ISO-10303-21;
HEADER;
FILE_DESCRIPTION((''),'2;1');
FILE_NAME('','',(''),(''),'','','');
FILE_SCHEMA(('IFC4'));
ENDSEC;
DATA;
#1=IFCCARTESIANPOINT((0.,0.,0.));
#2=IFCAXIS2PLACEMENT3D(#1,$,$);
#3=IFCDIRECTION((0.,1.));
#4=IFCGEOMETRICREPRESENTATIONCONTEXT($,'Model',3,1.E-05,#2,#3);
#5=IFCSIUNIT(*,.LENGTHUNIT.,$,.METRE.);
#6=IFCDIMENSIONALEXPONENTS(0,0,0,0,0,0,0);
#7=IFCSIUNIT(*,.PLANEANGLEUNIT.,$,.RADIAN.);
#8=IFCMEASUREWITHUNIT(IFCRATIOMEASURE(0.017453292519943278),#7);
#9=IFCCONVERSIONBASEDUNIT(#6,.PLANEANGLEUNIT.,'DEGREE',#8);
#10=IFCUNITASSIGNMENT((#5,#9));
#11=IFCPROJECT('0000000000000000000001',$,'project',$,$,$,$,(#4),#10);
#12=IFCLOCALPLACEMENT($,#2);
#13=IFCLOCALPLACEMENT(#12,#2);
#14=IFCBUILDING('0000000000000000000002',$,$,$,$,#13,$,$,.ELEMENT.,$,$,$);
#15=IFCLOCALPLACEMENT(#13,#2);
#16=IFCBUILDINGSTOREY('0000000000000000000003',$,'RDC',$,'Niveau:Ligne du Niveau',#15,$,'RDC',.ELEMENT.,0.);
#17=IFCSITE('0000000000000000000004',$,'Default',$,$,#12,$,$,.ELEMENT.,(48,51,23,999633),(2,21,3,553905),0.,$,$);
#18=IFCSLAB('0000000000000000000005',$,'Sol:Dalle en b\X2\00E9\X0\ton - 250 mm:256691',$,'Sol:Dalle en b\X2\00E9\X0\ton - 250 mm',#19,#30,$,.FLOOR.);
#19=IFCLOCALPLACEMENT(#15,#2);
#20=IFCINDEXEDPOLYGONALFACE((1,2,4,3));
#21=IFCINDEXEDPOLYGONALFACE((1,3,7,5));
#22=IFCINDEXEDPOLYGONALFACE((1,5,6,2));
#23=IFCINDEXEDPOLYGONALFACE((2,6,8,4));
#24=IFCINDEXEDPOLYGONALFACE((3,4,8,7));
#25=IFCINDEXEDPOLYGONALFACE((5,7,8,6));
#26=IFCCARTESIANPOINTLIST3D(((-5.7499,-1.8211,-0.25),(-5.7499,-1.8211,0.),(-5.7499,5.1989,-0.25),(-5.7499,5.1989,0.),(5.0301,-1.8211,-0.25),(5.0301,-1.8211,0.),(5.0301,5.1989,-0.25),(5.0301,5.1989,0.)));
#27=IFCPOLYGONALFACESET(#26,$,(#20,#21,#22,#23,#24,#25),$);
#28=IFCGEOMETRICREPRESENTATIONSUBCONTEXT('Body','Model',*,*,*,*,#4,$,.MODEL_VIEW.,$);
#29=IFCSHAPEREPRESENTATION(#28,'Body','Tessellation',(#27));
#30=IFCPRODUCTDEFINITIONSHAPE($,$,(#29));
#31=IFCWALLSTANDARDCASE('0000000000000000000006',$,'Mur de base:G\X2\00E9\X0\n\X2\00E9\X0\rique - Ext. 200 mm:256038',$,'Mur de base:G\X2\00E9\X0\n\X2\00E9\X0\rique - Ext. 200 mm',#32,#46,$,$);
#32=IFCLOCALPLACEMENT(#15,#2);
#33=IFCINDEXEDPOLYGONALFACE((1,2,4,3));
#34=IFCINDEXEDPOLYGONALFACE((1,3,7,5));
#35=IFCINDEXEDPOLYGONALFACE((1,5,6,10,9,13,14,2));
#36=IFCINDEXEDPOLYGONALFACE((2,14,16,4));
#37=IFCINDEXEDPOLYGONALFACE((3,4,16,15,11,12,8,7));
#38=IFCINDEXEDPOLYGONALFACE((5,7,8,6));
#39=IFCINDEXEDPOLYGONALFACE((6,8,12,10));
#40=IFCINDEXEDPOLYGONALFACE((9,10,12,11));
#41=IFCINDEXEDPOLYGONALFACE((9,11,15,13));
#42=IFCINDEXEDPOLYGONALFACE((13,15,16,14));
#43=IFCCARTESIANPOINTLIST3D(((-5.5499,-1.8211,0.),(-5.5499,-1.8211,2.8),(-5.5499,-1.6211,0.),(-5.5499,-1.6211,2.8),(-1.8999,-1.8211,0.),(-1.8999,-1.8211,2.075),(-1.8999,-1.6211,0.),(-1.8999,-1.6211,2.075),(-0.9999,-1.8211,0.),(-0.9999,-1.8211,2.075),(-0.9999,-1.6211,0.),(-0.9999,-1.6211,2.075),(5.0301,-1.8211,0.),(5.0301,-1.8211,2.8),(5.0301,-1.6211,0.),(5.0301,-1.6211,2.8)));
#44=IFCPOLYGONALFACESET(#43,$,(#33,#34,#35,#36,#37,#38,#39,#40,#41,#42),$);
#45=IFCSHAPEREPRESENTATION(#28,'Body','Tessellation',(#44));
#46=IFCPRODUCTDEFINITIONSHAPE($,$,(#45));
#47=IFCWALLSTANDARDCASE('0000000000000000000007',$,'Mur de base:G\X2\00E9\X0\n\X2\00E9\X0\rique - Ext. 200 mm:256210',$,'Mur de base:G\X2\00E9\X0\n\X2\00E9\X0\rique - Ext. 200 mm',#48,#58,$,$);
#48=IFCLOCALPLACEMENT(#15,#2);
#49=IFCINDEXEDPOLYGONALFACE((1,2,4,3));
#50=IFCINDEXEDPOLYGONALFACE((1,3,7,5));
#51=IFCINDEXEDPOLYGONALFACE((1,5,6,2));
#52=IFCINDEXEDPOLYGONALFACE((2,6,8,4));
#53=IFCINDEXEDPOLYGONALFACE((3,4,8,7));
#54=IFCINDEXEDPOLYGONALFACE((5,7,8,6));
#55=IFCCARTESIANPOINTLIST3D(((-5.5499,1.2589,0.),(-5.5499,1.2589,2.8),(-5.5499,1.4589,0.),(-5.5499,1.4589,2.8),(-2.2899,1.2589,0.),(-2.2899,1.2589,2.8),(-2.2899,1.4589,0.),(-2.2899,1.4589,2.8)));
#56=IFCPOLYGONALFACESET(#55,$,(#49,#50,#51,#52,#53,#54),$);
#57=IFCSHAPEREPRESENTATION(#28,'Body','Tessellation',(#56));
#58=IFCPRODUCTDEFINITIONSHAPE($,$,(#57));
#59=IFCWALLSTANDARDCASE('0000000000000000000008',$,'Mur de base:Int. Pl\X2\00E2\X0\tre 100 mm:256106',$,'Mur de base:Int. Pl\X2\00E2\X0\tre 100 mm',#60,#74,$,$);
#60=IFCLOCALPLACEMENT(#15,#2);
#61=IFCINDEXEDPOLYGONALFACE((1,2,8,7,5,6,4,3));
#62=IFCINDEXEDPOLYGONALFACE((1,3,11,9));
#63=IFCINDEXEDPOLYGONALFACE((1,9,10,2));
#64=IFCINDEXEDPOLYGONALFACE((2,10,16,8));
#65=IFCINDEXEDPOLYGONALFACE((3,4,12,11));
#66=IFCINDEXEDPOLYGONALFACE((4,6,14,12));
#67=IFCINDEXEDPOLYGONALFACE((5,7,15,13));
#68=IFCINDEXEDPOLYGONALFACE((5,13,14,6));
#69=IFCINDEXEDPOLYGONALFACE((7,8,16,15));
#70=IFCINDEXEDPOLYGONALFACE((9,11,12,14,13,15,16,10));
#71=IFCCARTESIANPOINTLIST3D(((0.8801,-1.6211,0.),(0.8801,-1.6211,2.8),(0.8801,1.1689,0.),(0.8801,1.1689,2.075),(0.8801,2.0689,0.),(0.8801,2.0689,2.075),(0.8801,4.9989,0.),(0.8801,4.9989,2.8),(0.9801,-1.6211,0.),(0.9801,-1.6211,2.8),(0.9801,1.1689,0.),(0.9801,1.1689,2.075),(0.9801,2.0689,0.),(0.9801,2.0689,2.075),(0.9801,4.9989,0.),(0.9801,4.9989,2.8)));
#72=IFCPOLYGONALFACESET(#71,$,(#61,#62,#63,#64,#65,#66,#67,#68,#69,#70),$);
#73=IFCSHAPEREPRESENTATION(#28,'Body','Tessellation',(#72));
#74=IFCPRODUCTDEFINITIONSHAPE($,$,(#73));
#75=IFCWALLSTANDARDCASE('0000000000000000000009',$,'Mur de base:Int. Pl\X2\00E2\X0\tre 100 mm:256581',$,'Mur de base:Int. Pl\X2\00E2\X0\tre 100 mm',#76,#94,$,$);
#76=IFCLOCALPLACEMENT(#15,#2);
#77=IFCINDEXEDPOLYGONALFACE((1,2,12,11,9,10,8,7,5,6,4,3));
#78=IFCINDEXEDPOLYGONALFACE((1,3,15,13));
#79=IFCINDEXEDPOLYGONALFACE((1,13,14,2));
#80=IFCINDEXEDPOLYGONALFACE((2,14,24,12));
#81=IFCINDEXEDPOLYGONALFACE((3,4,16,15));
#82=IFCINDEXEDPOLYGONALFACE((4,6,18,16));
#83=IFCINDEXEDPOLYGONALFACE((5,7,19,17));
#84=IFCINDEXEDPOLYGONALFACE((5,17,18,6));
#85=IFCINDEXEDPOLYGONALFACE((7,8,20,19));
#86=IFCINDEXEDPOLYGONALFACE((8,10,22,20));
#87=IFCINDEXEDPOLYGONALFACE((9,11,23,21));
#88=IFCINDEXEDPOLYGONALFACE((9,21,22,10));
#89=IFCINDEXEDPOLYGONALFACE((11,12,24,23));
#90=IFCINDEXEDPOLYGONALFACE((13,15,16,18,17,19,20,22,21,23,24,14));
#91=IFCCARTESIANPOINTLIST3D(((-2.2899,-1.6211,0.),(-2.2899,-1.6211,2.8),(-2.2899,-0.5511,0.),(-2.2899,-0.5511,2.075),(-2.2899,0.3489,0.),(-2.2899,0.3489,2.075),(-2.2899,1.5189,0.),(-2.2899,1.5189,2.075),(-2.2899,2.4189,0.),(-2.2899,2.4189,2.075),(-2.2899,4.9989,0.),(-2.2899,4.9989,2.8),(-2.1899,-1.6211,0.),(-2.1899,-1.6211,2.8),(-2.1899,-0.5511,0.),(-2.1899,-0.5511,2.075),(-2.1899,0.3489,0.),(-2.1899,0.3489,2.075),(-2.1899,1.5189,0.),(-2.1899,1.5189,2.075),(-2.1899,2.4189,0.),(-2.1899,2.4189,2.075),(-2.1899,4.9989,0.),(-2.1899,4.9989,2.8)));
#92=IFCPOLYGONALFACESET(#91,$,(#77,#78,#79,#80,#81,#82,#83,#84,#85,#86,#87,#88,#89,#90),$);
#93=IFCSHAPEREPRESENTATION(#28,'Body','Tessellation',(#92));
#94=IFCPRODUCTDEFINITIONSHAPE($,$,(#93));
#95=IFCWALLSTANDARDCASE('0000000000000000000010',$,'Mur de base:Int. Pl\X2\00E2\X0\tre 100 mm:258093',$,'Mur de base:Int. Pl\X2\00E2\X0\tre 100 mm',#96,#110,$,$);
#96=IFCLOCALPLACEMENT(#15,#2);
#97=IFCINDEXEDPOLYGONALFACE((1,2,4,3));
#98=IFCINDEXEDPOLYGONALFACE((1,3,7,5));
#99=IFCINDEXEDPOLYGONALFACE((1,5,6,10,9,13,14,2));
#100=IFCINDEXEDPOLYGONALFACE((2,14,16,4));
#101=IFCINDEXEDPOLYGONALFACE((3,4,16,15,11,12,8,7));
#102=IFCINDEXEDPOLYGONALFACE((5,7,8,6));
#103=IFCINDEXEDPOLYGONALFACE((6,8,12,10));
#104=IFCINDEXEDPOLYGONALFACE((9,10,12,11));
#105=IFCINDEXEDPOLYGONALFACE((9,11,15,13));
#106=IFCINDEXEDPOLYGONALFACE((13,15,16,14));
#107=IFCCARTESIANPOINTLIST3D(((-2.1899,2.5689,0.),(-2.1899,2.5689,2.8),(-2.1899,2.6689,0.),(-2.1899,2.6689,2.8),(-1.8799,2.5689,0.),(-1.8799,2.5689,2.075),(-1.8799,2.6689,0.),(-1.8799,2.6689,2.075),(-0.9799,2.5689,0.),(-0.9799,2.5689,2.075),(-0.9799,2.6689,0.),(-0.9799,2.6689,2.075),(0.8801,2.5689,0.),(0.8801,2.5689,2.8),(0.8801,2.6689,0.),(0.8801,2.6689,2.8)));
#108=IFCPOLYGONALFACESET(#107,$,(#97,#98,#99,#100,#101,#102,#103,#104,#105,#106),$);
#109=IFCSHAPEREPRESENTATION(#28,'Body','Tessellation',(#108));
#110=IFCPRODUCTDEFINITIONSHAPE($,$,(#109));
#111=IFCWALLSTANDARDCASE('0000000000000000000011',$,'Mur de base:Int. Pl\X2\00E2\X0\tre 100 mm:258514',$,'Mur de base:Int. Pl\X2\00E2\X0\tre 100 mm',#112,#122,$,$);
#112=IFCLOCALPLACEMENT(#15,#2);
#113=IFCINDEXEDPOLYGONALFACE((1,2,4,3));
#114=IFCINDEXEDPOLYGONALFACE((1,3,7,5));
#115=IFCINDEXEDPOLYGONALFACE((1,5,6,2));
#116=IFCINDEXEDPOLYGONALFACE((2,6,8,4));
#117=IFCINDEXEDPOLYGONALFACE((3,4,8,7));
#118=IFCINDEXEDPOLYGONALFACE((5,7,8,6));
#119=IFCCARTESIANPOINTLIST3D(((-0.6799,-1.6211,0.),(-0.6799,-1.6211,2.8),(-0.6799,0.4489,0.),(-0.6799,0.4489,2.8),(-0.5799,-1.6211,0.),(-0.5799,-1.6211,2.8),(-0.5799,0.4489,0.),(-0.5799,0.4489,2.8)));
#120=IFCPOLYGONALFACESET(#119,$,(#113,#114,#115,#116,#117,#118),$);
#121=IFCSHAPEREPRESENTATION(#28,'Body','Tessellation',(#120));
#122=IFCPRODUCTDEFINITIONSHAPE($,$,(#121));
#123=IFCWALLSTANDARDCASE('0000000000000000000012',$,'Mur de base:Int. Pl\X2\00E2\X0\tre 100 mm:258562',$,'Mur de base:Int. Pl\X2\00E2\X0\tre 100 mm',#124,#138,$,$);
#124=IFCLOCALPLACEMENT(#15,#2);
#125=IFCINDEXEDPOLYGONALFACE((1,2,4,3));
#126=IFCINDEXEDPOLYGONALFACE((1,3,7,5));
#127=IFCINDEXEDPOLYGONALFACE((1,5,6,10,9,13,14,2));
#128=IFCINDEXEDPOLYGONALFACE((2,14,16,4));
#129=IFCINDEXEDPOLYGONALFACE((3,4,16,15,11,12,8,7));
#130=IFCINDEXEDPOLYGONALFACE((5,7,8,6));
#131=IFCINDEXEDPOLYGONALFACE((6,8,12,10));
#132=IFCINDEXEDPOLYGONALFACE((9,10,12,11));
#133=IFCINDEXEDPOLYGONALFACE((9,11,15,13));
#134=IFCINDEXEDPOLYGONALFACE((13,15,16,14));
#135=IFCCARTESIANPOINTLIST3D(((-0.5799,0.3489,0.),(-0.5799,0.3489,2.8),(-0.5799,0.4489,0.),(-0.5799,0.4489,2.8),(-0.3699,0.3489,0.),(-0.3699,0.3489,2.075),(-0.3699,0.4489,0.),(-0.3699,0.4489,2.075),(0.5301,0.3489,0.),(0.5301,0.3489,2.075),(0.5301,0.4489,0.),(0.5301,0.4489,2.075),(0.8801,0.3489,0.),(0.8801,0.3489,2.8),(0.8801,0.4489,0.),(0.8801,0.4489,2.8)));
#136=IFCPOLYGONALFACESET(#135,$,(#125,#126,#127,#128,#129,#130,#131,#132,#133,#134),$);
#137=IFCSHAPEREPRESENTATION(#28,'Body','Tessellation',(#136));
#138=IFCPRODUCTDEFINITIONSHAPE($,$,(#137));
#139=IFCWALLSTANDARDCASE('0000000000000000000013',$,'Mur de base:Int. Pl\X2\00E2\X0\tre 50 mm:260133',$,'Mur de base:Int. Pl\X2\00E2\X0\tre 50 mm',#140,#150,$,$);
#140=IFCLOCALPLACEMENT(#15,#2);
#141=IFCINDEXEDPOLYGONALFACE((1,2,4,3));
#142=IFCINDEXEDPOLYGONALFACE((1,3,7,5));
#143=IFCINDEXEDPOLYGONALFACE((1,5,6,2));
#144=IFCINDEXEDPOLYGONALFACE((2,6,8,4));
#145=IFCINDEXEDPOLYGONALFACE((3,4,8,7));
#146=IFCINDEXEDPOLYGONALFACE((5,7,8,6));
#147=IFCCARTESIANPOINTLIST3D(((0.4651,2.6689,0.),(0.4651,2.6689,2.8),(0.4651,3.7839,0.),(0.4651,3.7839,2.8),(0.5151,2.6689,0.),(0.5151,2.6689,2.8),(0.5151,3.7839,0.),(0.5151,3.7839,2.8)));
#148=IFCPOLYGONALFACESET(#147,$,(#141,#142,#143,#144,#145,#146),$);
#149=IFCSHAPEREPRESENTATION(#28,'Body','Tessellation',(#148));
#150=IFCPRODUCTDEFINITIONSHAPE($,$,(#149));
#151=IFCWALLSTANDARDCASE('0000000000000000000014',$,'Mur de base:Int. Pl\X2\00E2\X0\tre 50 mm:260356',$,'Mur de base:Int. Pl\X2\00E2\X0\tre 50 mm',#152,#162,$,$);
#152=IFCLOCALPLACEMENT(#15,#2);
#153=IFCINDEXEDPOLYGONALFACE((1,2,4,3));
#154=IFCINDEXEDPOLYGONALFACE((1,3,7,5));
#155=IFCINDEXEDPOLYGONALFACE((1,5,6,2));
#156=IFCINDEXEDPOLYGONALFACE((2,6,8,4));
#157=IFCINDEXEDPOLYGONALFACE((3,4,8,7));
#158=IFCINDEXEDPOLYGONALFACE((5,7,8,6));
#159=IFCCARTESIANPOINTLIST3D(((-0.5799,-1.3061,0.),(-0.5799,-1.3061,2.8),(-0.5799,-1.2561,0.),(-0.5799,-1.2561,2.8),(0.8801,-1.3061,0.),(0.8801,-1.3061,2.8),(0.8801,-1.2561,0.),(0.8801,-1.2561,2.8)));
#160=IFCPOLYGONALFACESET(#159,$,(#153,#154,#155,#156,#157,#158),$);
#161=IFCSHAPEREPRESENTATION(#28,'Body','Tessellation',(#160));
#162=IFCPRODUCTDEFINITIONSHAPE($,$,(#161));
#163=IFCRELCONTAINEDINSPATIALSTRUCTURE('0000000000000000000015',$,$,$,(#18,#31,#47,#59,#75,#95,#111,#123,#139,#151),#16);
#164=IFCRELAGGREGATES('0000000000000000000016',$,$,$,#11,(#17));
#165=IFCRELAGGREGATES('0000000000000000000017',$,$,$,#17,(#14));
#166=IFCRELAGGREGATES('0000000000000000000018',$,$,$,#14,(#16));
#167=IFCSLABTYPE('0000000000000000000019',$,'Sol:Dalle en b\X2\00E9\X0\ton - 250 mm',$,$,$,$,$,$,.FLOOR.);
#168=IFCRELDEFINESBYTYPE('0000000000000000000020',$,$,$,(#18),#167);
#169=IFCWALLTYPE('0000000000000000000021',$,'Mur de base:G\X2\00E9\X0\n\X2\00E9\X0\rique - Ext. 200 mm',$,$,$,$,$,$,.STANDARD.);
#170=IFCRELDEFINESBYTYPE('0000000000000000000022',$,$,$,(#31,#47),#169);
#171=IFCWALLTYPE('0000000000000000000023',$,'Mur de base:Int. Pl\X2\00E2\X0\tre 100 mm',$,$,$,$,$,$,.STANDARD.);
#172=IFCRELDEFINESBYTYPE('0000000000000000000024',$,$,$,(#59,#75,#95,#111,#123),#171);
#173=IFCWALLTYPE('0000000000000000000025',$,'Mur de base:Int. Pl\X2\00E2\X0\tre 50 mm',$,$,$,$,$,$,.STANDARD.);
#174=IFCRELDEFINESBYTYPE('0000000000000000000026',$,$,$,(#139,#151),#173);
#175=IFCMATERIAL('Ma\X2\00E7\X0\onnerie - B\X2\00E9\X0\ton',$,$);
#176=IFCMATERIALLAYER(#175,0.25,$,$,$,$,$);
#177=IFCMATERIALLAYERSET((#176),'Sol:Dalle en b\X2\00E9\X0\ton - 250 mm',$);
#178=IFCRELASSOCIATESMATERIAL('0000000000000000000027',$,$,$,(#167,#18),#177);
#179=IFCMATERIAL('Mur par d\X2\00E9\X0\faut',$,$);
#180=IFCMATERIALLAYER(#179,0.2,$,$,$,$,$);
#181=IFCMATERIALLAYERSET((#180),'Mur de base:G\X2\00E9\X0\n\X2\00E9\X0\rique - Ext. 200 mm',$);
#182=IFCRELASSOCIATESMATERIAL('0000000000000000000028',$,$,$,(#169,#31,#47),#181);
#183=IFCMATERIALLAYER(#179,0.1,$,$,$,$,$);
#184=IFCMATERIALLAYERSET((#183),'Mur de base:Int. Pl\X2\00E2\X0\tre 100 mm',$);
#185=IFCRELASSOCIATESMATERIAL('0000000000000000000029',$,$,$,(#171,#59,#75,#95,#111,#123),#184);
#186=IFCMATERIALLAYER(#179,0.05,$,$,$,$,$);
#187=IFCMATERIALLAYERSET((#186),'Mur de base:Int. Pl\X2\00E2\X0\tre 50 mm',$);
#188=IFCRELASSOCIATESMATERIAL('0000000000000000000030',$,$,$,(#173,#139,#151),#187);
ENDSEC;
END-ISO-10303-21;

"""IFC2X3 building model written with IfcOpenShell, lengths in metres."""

from ifc_helpers import new_model, entity, si_unit, converted_unit, direction, frame, frame_2d, origin, origin_2d_with_axis, place, context, subcontext, project, spatial, rectangle, extrude, material, layer, layer_set, layer_usage, type_object, element, save


model = new_model("IFC2X3")

# Units and contexts
model_context = context("Model", 3, precision=1e-05, world=origin(), true_north=direction((0.0, 1.0)))
body_context = subcontext(model_context, "Body", "Model", "MODEL_VIEW")
ifc_project = project(units=[si_unit("LENGTHUNIT", "METRE"), converted_unit("PLANEANGLEUNIT", "DEGREE", entity("IfcRatioMeasure", 0.017453292519943278), si_unit("PLANEANGLEUNIT", "RADIAN"), dimensions=[0, 0, 0, 0, 0, 0, 0])], contexts=[model_context])

# Site, building, storey
site_placement = place(None, origin())
site = spatial("IfcSite", under=ifc_project, at=site_placement, Name="Default", CompositionType="ELEMENT", RefLatitude=(48, 51, 23, 999633), RefLongitude=(2, 21, 3, 553905), RefElevation=0.0)
building_placement = place(site_placement, origin())
building = spatial("IfcBuilding", under=site, at=building_placement, CompositionType="ELEMENT")
storey_placement = place(building_placement, origin())
storey = spatial("IfcBuildingStorey", under=building, at=storey_placement, Name="RDC", ObjectType="Niveau:Ligne du Niveau", LongName="RDC", CompositionType="ELEMENT", Elevation=0.0)

# Slab
ifc_material_1 = material(Name="Maçonnerie - Béton")
ifc_layer_1 = layer(ifc_material_1, 0.25)
ifc_layer_set_1 = layer_set([ifc_layer_1], Name="Sol:Dalle en béton - 250 mm")
ifc_layer_usage_1 = layer_usage(ifc_layer_set_1, "AXIS3", "POSITIVE", 0.0)
slab_type = type_object("IfcSlabType", Name="Sol:Dalle en béton - 250 mm", PredefinedType="FLOOR", material=ifc_layer_set_1)
slab_placement = place(storey_placement, origin())
element("IfcSlab", 1, at=slab_placement, inside=storey, type_object=slab_type, material=ifc_layer_usage_1, Name="Sol:Dalle en béton - 250 mm:256691", ObjectType="Sol:Dalle en béton - 250 mm", PredefinedType="FLOOR", context=body_context, shape_type="SweptSolid", body=[
    extrude(rectangle(XDim=7.02, YDim=10.78, at=origin_2d_with_axis()), frame((-0.3599, 1.6889, 0.0), z_axis=(0.0, 0.0, -1.0), x_axis=(0.0, 1.0, 0.0)), (0.0, 0.0, 1.0), 0.25),
])

# Wall, opening
ifc_material_2 = material(Name="Mur par défaut")
ifc_layer_2 = layer(ifc_material_2, 0.2)
ifc_layer_set_2 = layer_set([ifc_layer_2], Name="Mur de base:Générique - Ext. 200 mm")
ifc_layer_usage_2 = layer_usage(ifc_layer_set_2, "AXIS2", "NEGATIVE", 0.1)
wall_type_1 = type_object("IfcWallType", Name="Mur de base:Générique - Ext. 200 mm", PredefinedType="STANDARD", material=ifc_layer_set_2)
wall_1_placement = place(storey_placement, frame((5.0301, -1.7211, 0.0), z_axis=(0.0, 0.0, 1.0), x_axis=(-1.0, 0.0, 0.0)))
wall_1 = element("IfcWallStandardCase", 2, at=wall_1_placement, inside=storey, type_object=wall_type_1, material=ifc_layer_usage_2, Name="Mur de base:Générique - Ext. 200 mm:256038", ObjectType="Mur de base:Générique - Ext. 200 mm", context=body_context, shape_type="SweptSolid", body=[
    extrude(rectangle(XDim=10.58, YDim=0.2, at=frame_2d((5.29, 0.0), x_axis=(1.0, 0.0))), origin(), (0.0, 0.0, 1.0), 2.8),
])
opening_1_placement = place(wall_1_placement, frame((6.03, -0.1, 0.0)))
element("IfcOpeningElement", 3, at=opening_1_placement, cuts=wall_1, ObjectType="Opening", context=body_context, shape_type="SweptSolid", body=[
    extrude(rectangle(XDim=2.075, YDim=0.9, at=frame_2d((1.0375, 0.45), x_axis=(1.0, 0.0))), frame((0.0, 0.0, 0.0), z_axis=(0.0, 1.0, 0.0), x_axis=(0.0, 0.0, 1.0)), (0.0, 0.0, 1.0), 0.2),
])

# Wall
wall_2_placement = place(storey_placement, frame((-2.2899, 1.3589, 0.0), z_axis=(0.0, 0.0, 1.0), x_axis=(-1.0, 0.0, 0.0)))
element("IfcWallStandardCase", 4, at=wall_2_placement, inside=storey, type_object=wall_type_1, material=ifc_layer_usage_2, Name="Mur de base:Générique - Ext. 200 mm:256210", ObjectType="Mur de base:Générique - Ext. 200 mm", context=body_context, shape_type="SweptSolid", body=[
    extrude(rectangle(XDim=3.26, YDim=0.2, at=frame_2d((1.63, 0.0), x_axis=(-1.0, 0.0))), origin(), (0.0, 0.0, 1.0), 2.8),
])

# Wall, opening
ifc_layer_3 = layer(ifc_material_2, 0.1)
ifc_layer_set_3 = layer_set([ifc_layer_3], Name="Mur de base:Int. Plâtre 100 mm")
ifc_layer_usage_3 = layer_usage(ifc_layer_set_3, "AXIS2", "NEGATIVE", 0.05)
wall_type_2 = type_object("IfcWallType", Name="Mur de base:Int. Plâtre 100 mm", PredefinedType="STANDARD", material=ifc_layer_set_3)
wall_3_placement = place(storey_placement, frame((0.9301, -1.6211, 0.0), z_axis=(0.0, 0.0, 1.0), x_axis=(0.0, 1.0, 0.0)))
wall_3 = element("IfcWallStandardCase", 5, at=wall_3_placement, inside=storey, type_object=wall_type_2, material=ifc_layer_usage_3, Name="Mur de base:Int. Plâtre 100 mm:256106", ObjectType="Mur de base:Int. Plâtre 100 mm", context=body_context, shape_type="SweptSolid", body=[
    extrude(rectangle(XDim=6.62, YDim=0.1, at=frame_2d((3.31, 0.0), x_axis=(1.0, 0.0))), origin(), (0.0, 0.0, 1.0), 2.8),
])
opening_2_placement = place(wall_3_placement, frame((3.69, 0.05, 0.0)))
element("IfcOpeningElement", 6, at=opening_2_placement, cuts=wall_3, ObjectType="Opening", context=body_context, shape_type="SweptSolid", body=[
    extrude(rectangle(XDim=2.075, YDim=0.9, at=frame_2d((1.0375, 0.45), x_axis=(1.0, 0.0))), frame((0.0, 0.0, 0.0), z_axis=(0.0, -1.0, 0.0), x_axis=(0.0, 0.0, 1.0)), (0.0, 0.0, 1.0), 0.1),
])

# Wall, openings
wall_4_placement = place(storey_placement, frame((-2.2399, 4.9989, 0.0), z_axis=(0.0, 0.0, 1.0), x_axis=(0.0, -1.0, 0.0)))
wall_4 = element("IfcWallStandardCase", 7, at=wall_4_placement, inside=storey, type_object=wall_type_2, material=ifc_layer_usage_3, Name="Mur de base:Int. Plâtre 100 mm:256581", ObjectType="Mur de base:Int. Plâtre 100 mm", context=body_context, shape_type="SweptSolid", body=[
    extrude(rectangle(XDim=6.62, YDim=0.1, at=frame_2d((3.31, 0.0), x_axis=(-1.0, 0.0))), origin(), (0.0, 0.0, 1.0), 2.8),
])
opening_3_placement = place(wall_4_placement, frame((5.55, 0.05, 0.0)))
element("IfcOpeningElement", 8, at=opening_3_placement, cuts=wall_4, ObjectType="Opening", context=body_context, shape_type="SweptSolid", body=[
    extrude(rectangle(XDim=2.075, YDim=0.9, at=frame_2d((1.0375, 0.45), x_axis=(1.0, 0.0))), frame((0.0, 0.0, 0.0), z_axis=(0.0, -1.0, 0.0), x_axis=(0.0, 0.0, 1.0)), (0.0, 0.0, 1.0), 0.1),
])
opening_4_placement = place(wall_4_placement, frame((3.48, 0.05, 0.0)))
element("IfcOpeningElement", 9, at=opening_4_placement, cuts=wall_4, ObjectType="Opening", context=body_context, shape_type="SweptSolid", body=[
    extrude(rectangle(XDim=2.075, YDim=0.9, at=frame_2d((1.0375, 0.45), x_axis=(1.0, 0.0))), frame((0.0, 0.0, 0.0), z_axis=(0.0, -1.0, 0.0), x_axis=(0.0, 0.0, 1.0)), (0.0, 0.0, 1.0), 0.1),
])

# Wall, opening
wall_5_placement = place(storey_placement, frame((0.8801, 2.6189, 0.0), z_axis=(0.0, 0.0, 1.0), x_axis=(-1.0, 0.0, 0.0)))
wall_5 = element("IfcWallStandardCase", 10, at=wall_5_placement, inside=storey, type_object=wall_type_2, material=ifc_layer_usage_3, Name="Mur de base:Int. Plâtre 100 mm:258093", ObjectType="Mur de base:Int. Plâtre 100 mm", context=body_context, shape_type="SweptSolid", body=[
    extrude(rectangle(XDim=3.07, YDim=0.1, at=frame_2d((1.535, 0.0), x_axis=(1.0, 0.0))), origin(), (0.0, 0.0, 1.0), 2.8),
])
opening_5_placement = place(wall_5_placement, frame((2.76, 0.05, 0.0)))
element("IfcOpeningElement", 11, at=opening_5_placement, cuts=wall_5, ObjectType="Opening", context=body_context, shape_type="SweptSolid", body=[
    extrude(rectangle(XDim=2.075, YDim=0.9, at=frame_2d((1.0375, 0.45), x_axis=(1.0, 0.0))), frame((0.0, 0.0, 0.0), z_axis=(0.0, -1.0, 0.0), x_axis=(0.0, 0.0, 1.0)), (0.0, 0.0, 1.0), 0.1),
])

# Wall
wall_6_placement = place(storey_placement, frame((-0.6299, -1.6211, 0.0), z_axis=(0.0, 0.0, 1.0), x_axis=(0.0, 1.0, 0.0)))
element("IfcWallStandardCase", 12, at=wall_6_placement, inside=storey, type_object=wall_type_2, material=ifc_layer_usage_3, Name="Mur de base:Int. Plâtre 100 mm:258514", ObjectType="Mur de base:Int. Plâtre 100 mm", context=body_context, shape_type="SweptSolid", body=[
    extrude(rectangle(XDim=2.07, YDim=0.1, at=frame_2d((1.035, 0.0), x_axis=(-1.0, 0.0))), origin(), (0.0, 0.0, 1.0), 2.8),
])

# Wall, opening
wall_7_placement = place(storey_placement, frame((-0.5799, 0.3989, 0.0)))
wall_7 = element("IfcWallStandardCase", 13, at=wall_7_placement, inside=storey, type_object=wall_type_2, material=ifc_layer_usage_3, Name="Mur de base:Int. Plâtre 100 mm:258562", ObjectType="Mur de base:Int. Plâtre 100 mm", context=body_context, shape_type="SweptSolid", body=[
    extrude(rectangle(XDim=1.46, YDim=0.1, at=frame_2d((0.73, 0.0), x_axis=(-1.0, 0.0))), origin(), (0.0, 0.0, 1.0), 2.8),
])
opening_6_placement = place(wall_7_placement, frame((0.21, -0.05, 0.0)))
element("IfcOpeningElement", 14, at=opening_6_placement, cuts=wall_7, ObjectType="Opening", context=body_context, shape_type="SweptSolid", body=[
    extrude(rectangle(XDim=2.075, YDim=0.9, at=frame_2d((1.0375, 0.45), x_axis=(1.0, 0.0))), frame((0.0, 0.0, 0.0), z_axis=(0.0, 1.0, 0.0), x_axis=(0.0, 0.0, 1.0)), (0.0, 0.0, 1.0), 0.1),
])

# Walls
ifc_layer_4 = layer(ifc_material_2, 0.05)
ifc_layer_set_4 = layer_set([ifc_layer_4], Name="Mur de base:Int. Plâtre 50 mm")
ifc_layer_usage_4 = layer_usage(ifc_layer_set_4, "AXIS2", "NEGATIVE", 0.025)
wall_type_3 = type_object("IfcWallType", Name="Mur de base:Int. Plâtre 50 mm", PredefinedType="STANDARD", material=ifc_layer_set_4)
wall_8_placement = place(storey_placement, frame((0.4901, 3.7839, 0.0), z_axis=(0.0, 0.0, 1.0), x_axis=(0.0, -1.0, 0.0)))
element("IfcWallStandardCase", 15, at=wall_8_placement, inside=storey, type_object=wall_type_3, material=ifc_layer_usage_4, Name="Mur de base:Int. Plâtre 50 mm:260133", ObjectType="Mur de base:Int. Plâtre 50 mm", context=body_context, shape_type="SweptSolid", body=[
    extrude(rectangle(XDim=1.115, YDim=0.05, at=frame_2d((0.5575, 0.0), x_axis=(-1.0, 0.0))), origin(), (0.0, 0.0, 1.0), 2.8),
])
wall_9_placement = place(storey_placement, frame((0.8801, -1.2811, 0.0), z_axis=(0.0, 0.0, 1.0), x_axis=(-1.0, 0.0, 0.0)))
element("IfcWallStandardCase", 16, at=wall_9_placement, inside=storey, type_object=wall_type_3, material=ifc_layer_usage_4, Name="Mur de base:Int. Plâtre 50 mm:260356", ObjectType="Mur de base:Int. Plâtre 50 mm", context=body_context, shape_type="SweptSolid", body=[
    extrude(rectangle(XDim=1.46, YDim=0.05, at=frame_2d((0.73, 0.0), x_axis=(-1.0, 0.0))), origin(), (0.0, 0.0, 1.0), 2.8),
])

save(model, "model.ifc")
